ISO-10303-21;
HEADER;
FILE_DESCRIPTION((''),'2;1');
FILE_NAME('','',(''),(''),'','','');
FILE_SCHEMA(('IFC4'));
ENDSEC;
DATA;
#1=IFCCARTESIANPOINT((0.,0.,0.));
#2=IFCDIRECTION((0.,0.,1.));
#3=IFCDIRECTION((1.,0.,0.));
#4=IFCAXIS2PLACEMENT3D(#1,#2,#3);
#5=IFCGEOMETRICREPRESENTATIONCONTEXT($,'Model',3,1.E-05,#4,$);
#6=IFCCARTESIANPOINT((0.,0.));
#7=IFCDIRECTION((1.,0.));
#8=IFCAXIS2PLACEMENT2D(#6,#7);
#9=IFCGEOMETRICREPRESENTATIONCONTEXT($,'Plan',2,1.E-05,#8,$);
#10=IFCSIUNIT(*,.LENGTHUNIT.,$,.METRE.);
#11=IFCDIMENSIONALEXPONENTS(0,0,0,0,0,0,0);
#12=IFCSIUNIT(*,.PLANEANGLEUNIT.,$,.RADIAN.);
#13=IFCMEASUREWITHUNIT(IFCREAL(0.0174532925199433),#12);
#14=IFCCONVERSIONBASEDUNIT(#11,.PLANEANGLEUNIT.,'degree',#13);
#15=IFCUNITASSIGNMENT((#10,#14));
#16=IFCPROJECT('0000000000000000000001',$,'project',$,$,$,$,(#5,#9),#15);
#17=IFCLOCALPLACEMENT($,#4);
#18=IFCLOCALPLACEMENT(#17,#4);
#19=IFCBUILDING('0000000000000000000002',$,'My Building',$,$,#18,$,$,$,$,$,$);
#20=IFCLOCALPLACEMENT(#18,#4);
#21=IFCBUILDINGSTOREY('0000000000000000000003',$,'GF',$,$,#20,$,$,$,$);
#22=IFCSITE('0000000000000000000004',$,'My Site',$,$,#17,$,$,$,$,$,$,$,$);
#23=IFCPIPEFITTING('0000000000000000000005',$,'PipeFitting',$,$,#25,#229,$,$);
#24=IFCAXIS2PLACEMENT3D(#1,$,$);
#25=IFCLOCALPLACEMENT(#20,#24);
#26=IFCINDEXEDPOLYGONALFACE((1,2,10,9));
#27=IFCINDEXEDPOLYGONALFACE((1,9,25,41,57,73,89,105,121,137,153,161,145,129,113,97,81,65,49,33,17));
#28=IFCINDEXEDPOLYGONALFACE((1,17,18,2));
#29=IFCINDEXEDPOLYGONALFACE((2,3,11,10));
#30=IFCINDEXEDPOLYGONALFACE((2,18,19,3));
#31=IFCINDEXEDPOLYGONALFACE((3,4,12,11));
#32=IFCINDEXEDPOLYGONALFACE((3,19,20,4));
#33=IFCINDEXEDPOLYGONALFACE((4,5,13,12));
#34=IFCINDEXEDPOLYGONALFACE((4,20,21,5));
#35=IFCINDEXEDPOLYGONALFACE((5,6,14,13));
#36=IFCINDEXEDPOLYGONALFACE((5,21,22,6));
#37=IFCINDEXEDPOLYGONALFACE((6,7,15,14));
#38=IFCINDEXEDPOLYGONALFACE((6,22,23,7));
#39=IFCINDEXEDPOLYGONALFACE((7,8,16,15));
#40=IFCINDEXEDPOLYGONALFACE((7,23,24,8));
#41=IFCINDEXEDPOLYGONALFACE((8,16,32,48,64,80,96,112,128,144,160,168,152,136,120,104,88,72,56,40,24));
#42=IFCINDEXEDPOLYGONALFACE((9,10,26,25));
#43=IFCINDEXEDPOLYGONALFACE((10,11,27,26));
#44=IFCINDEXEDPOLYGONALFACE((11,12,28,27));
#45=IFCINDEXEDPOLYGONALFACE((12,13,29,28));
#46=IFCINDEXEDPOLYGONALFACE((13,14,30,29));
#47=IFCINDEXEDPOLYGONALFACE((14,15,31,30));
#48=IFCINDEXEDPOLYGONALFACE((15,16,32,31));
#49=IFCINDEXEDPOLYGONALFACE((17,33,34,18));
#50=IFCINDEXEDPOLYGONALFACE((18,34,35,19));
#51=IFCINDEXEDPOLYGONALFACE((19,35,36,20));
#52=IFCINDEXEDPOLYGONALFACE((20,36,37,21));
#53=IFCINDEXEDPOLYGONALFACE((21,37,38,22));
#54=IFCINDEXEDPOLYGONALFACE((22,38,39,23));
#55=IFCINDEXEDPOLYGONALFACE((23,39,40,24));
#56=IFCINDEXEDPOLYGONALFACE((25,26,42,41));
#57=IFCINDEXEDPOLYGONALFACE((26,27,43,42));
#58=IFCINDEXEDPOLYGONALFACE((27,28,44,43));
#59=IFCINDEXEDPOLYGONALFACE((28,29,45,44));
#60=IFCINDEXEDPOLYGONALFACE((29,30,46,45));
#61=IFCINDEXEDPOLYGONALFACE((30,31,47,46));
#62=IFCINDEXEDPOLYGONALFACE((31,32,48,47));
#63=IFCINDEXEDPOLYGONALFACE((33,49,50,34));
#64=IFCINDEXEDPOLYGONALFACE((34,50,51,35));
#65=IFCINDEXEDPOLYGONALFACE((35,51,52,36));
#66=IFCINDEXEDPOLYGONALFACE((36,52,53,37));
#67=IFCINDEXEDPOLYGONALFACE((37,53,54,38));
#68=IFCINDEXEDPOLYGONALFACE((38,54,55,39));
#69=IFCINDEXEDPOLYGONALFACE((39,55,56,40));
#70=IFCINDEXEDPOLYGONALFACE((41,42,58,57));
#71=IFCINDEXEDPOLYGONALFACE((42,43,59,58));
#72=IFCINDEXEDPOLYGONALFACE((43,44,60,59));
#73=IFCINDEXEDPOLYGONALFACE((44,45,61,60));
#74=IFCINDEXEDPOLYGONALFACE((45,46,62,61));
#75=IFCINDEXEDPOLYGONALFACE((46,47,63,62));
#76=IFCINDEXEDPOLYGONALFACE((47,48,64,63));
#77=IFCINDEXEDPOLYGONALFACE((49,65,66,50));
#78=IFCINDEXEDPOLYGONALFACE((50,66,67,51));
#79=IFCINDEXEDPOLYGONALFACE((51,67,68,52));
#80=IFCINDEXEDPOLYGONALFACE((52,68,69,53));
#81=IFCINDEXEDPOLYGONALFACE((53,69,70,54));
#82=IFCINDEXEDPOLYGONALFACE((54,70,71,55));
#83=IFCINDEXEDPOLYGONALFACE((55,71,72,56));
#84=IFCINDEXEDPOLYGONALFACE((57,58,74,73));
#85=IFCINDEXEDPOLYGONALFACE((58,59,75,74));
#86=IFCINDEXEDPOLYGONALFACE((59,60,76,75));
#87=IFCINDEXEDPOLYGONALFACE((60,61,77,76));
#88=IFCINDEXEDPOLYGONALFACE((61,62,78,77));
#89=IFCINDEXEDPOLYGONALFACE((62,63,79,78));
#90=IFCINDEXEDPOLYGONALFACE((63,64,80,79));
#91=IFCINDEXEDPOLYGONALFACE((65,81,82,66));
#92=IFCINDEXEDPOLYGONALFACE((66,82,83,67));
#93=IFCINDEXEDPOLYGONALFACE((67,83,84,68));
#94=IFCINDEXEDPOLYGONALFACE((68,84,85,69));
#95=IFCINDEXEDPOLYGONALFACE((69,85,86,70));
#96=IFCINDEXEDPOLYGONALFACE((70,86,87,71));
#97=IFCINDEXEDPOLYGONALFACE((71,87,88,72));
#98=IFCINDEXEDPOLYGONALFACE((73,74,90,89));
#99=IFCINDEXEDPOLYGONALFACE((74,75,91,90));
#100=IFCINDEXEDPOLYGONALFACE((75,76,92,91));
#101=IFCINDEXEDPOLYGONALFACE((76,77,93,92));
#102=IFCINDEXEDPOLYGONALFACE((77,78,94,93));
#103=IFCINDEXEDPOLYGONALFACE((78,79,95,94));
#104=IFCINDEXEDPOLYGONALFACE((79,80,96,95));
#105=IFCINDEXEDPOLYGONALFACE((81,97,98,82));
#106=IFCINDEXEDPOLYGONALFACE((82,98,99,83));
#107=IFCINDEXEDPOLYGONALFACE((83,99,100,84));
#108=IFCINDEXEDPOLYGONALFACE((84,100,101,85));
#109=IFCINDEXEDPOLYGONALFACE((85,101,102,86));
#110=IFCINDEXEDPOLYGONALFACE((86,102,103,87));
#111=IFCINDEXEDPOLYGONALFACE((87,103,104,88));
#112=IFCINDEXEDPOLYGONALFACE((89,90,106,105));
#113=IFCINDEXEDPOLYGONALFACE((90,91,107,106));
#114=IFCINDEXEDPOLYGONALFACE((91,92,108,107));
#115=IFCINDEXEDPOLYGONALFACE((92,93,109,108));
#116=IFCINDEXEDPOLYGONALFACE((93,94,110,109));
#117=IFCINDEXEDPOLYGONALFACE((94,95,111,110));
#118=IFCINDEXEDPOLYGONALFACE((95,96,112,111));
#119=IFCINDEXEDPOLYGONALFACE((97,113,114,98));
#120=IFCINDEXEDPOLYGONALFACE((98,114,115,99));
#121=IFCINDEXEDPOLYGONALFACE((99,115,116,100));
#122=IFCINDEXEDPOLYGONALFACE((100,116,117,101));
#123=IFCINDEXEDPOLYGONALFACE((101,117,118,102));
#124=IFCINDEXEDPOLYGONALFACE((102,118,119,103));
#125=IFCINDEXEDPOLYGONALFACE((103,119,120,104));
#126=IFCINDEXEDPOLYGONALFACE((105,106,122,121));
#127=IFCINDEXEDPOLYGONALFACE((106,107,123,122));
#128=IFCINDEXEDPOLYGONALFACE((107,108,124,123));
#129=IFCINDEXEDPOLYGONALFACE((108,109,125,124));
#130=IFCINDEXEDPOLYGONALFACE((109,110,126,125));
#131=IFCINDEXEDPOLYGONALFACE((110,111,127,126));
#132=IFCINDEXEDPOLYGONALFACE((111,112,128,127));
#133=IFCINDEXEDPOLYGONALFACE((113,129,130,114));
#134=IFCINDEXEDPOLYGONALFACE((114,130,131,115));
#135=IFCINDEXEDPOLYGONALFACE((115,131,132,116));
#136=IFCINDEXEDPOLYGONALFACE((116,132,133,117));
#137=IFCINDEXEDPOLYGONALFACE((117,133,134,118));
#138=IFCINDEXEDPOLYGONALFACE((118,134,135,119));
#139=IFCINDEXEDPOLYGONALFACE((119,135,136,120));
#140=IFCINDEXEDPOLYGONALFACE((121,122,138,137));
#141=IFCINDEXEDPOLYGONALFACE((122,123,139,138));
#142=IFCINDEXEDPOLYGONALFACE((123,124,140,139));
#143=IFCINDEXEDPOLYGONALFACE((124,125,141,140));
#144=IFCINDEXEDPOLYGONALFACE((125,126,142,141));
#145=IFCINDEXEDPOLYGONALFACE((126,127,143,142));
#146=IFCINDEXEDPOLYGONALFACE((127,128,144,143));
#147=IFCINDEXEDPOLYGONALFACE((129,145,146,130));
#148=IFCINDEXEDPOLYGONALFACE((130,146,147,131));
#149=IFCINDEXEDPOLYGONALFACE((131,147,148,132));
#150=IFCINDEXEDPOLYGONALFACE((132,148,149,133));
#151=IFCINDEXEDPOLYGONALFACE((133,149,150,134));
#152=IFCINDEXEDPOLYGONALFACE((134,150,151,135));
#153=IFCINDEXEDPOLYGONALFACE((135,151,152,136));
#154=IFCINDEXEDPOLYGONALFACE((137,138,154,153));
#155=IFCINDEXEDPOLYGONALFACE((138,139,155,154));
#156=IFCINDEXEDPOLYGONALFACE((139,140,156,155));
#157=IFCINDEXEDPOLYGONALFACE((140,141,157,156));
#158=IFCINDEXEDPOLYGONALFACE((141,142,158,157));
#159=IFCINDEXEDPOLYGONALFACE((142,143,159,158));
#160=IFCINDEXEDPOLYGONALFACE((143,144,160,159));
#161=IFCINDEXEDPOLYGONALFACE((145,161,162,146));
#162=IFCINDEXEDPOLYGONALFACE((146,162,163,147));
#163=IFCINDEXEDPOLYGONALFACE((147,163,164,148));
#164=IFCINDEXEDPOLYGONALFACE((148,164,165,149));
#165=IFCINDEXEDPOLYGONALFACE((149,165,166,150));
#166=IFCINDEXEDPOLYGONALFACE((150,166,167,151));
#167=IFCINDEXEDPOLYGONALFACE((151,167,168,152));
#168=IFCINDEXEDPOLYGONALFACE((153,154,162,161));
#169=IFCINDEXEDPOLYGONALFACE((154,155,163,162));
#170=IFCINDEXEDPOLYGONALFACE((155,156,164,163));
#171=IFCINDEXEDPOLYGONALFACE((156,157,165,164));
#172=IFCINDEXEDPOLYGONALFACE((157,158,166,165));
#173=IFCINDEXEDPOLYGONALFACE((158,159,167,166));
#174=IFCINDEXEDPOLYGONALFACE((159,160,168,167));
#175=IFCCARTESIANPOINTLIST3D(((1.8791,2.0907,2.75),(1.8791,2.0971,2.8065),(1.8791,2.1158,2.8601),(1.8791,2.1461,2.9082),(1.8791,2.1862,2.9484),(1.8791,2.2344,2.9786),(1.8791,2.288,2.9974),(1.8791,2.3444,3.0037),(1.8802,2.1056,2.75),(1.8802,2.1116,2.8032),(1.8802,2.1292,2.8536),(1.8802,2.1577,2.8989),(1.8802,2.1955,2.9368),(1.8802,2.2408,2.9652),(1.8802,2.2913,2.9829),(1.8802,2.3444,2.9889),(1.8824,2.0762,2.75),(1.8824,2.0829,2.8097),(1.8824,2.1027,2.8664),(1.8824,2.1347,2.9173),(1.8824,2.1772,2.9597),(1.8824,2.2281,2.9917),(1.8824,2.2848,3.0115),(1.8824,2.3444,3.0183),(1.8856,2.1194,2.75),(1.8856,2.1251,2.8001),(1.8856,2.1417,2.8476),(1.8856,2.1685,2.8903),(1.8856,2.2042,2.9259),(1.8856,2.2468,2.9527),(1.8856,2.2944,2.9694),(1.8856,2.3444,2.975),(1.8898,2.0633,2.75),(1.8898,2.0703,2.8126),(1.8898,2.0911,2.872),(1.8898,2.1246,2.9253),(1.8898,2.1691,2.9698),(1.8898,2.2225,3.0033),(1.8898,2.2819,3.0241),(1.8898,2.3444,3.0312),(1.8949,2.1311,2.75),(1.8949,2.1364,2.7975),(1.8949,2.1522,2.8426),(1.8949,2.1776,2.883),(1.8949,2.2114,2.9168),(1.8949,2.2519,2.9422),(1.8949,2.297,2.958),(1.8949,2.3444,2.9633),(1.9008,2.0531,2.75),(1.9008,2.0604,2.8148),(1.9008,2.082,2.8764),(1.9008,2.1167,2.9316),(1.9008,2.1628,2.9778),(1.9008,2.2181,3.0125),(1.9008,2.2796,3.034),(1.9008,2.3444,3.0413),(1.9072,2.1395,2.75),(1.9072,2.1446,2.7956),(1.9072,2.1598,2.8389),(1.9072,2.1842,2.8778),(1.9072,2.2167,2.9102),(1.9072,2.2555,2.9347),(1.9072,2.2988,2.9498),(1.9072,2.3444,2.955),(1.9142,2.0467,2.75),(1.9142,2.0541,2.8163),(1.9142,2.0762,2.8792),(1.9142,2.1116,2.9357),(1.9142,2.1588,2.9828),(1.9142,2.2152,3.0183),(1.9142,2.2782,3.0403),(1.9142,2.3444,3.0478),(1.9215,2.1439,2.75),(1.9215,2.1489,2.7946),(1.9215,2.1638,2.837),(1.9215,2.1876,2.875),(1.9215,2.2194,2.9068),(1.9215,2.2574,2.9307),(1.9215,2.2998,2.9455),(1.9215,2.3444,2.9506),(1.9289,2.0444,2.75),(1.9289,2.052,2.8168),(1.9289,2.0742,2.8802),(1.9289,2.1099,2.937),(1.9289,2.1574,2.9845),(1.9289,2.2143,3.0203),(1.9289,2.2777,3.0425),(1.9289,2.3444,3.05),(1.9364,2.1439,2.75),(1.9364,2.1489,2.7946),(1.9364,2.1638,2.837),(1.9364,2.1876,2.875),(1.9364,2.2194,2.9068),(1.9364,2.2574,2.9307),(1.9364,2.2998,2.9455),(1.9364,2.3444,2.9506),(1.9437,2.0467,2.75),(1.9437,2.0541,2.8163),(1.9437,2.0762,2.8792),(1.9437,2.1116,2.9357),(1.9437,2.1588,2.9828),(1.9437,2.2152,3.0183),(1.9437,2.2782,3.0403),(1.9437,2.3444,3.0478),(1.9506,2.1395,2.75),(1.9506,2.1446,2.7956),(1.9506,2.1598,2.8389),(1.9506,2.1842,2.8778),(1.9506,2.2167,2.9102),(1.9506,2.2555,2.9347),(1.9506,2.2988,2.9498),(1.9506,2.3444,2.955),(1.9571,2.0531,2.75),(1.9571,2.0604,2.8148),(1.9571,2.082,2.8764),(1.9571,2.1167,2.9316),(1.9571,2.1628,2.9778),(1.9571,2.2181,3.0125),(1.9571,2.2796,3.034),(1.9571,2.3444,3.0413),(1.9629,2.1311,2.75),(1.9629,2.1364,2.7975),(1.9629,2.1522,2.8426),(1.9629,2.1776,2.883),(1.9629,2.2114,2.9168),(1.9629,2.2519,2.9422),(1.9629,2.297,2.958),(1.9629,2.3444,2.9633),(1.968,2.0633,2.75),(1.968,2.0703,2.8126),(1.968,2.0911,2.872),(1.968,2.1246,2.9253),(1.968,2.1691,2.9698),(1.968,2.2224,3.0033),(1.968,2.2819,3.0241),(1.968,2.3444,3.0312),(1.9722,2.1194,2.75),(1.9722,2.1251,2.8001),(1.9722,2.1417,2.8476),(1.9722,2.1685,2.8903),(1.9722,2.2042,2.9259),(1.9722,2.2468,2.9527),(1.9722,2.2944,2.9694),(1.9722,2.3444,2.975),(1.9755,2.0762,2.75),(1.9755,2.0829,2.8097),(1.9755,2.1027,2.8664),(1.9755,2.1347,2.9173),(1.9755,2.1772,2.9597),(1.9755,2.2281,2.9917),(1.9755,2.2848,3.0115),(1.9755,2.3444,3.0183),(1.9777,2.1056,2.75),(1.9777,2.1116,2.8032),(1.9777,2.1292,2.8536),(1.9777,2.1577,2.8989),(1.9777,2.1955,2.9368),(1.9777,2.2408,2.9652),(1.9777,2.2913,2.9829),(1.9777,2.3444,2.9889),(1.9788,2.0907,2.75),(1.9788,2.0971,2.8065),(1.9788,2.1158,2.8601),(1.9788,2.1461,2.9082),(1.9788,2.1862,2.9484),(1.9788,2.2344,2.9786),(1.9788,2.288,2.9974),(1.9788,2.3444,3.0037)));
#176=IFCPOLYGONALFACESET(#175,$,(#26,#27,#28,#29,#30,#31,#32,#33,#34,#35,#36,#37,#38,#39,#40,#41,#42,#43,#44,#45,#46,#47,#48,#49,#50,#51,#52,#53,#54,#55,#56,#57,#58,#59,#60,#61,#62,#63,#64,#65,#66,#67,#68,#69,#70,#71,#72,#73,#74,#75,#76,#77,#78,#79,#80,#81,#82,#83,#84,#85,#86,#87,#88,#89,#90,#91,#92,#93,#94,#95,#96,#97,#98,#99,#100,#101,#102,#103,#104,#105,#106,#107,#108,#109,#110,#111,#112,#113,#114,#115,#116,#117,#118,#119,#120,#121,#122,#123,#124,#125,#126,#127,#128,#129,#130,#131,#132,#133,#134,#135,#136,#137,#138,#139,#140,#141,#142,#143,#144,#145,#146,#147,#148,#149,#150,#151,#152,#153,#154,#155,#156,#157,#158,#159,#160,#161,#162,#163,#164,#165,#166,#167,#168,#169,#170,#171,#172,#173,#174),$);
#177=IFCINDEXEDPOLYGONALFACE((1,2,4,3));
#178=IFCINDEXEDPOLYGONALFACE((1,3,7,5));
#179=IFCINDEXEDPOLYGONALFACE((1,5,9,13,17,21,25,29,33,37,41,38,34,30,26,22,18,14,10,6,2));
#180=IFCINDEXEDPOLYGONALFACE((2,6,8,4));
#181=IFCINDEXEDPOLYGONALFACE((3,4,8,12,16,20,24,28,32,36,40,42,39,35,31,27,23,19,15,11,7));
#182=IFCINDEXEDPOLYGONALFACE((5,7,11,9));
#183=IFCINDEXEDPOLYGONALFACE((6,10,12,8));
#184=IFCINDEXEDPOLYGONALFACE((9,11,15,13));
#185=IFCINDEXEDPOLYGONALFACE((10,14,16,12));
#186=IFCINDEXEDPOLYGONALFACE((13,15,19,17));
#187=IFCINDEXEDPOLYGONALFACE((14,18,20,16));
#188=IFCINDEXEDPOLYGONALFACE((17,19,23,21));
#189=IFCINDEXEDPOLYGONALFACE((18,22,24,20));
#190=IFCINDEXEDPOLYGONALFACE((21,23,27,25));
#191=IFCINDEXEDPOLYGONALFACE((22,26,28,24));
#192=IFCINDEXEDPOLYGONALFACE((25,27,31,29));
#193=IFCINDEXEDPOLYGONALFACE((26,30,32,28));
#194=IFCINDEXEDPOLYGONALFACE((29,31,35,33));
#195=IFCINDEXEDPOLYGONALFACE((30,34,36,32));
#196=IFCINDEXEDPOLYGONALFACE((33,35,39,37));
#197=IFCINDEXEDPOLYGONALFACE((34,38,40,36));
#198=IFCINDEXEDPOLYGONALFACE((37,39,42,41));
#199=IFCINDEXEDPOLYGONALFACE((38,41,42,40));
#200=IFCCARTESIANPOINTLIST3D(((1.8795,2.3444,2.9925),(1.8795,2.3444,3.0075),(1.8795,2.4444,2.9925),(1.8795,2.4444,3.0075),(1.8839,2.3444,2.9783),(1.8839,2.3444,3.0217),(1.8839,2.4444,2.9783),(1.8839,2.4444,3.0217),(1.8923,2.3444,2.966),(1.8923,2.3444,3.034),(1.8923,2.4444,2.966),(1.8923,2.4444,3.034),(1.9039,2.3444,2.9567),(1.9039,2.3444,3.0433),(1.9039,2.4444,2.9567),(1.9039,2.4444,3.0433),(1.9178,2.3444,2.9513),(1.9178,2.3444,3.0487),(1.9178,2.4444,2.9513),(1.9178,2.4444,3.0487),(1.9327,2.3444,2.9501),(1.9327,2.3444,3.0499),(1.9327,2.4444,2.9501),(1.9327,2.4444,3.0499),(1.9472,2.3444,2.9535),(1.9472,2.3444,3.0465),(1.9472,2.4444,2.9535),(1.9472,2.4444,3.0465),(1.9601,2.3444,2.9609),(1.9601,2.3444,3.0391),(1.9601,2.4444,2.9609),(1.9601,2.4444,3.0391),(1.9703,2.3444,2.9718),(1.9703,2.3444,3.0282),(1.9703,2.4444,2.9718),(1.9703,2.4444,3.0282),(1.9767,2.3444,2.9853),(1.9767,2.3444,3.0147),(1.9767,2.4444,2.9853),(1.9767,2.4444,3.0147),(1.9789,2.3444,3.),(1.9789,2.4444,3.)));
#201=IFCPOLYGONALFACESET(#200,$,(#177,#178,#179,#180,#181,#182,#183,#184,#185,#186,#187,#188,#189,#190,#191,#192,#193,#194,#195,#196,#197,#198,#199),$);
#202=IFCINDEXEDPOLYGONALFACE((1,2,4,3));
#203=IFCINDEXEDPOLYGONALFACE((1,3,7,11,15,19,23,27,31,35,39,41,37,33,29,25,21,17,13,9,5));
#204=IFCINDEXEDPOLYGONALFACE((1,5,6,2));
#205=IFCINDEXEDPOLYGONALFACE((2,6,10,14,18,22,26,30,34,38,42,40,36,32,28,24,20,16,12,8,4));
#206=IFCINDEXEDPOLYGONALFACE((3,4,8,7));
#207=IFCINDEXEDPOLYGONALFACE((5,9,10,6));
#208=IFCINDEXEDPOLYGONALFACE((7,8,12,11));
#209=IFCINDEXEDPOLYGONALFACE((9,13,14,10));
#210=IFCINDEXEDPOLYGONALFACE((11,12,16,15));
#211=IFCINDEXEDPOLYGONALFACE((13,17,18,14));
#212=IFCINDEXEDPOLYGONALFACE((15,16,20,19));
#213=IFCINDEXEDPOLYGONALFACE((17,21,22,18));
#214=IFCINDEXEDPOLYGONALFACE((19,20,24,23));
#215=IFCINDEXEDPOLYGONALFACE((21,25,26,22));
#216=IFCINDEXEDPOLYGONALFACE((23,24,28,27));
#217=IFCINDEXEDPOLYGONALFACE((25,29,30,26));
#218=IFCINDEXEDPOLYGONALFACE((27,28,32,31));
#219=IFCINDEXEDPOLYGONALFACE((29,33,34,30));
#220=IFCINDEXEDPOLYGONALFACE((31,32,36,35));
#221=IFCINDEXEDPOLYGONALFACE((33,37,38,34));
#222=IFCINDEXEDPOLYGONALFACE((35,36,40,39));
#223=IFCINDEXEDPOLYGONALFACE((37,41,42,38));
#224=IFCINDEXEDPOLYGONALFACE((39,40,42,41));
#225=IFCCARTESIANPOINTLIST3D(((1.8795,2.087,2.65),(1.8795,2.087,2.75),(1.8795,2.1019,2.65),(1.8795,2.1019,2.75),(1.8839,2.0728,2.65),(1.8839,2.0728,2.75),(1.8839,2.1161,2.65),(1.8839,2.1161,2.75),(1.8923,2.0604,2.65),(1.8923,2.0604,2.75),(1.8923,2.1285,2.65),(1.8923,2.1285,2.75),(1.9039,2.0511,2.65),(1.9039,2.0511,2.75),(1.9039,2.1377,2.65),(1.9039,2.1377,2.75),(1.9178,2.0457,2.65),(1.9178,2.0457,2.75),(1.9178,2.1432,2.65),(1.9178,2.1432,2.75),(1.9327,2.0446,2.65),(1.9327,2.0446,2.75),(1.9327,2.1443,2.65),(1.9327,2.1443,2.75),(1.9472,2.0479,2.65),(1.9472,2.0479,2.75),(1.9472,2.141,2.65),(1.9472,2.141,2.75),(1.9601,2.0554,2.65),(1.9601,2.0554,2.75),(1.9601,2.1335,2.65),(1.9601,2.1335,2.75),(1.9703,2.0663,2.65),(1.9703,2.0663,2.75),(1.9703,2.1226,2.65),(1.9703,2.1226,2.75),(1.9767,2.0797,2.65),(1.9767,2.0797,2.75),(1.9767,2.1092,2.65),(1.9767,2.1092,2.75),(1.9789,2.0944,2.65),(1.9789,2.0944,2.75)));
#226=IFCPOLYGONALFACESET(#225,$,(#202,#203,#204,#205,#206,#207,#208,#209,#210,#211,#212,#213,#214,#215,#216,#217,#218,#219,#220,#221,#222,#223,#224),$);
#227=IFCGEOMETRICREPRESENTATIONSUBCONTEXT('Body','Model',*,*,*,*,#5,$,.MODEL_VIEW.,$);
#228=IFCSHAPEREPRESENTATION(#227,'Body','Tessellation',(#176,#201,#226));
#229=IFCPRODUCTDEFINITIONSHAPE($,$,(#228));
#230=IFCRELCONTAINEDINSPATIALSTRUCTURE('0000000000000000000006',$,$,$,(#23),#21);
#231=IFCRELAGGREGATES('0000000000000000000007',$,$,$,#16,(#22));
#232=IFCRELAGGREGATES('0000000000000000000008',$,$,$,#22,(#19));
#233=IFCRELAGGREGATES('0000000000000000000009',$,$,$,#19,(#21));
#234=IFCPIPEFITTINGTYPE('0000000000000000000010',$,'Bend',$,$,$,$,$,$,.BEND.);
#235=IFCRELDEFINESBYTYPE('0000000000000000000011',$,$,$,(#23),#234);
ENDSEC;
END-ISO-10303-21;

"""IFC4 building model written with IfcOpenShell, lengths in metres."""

from ifc_helpers import new_model, entity, si_unit, converted_unit, frame, origin_with_axes, origin_2d_with_axis, place, context, subcontext, project, spatial, circle, extrude, source, transform, mapped, type_object, type_shapes, element, save


model = new_model("IFC4")

# Units and contexts
model_context = context("Model", 3, precision=1e-05, world=origin_with_axes())
plan_context = context("Plan", 2, precision=1e-05, world=origin_2d_with_axis())
body_context_1 = subcontext(model_context, "Body", "Model", "MODEL_VIEW")
ifc_project = project(units=[si_unit("LENGTHUNIT", "METRE"), converted_unit("PLANEANGLEUNIT", "degree", entity("IfcReal", 0.0174532925199433), si_unit("PLANEANGLEUNIT", "RADIAN"), dimensions=[0, 0, 0, 0, 0, 0, 0])], contexts=[model_context, plan_context])

# Site, building, storey
site_placement = place(None, origin_with_axes())
site = spatial("IfcSite", under=ifc_project, at=site_placement, Name="My Site")
building_placement = place(site_placement, origin_with_axes())
building = spatial("IfcBuilding", under=site, at=building_placement, Name="My Building")
storey_placement = place(building_placement, origin_with_axes())
storey = spatial("IfcBuildingStorey", under=building, at=storey_placement, Name="GF")

# Pipe fitting
pipe_fitting_type = type_object("IfcPipeFittingType", Name="Bend", PredefinedType="BEND")
shared_shape_1 = source(origin_with_axes(), body_context_1, "Body", "SolidModel", [
    entity("IfcSweptDiskSolid", entity("IfcIndexedPolyCurve", entity("IfcCartesianPointList3D", [[0.0, 0.0, 0.1], [0.0, -0.0732, 0.2768], [0.0, -0.25, 0.35]]), [entity("IfcArcIndex", [1, 2, 3])]), 0.05),
    extrude(circle(Radius=0.05), origin_with_axes(), (0.0, 0.0, 1.0), 0.1),
    extrude(circle(Radius=0.05), frame((0.0, -0.25, 0.35), z_axis=(0.0, -1.0, 0.0), x_axis=(1.0, 0.0, 0.0)), (0.0, 0.0, 1.0), 0.1),
])
type_shapes(pipe_fitting_type, [shared_shape_1])
for number, where, z_axis, x_axis, name in (
    (1, (1.9289, 2.4444, 3.0), (0.0, -1.0, 0.0), (1.0, 0.0, 0.0), "PipeFitting"),
):
    element("IfcPipeFitting", number, at=place(storey_placement, frame(where, z_axis=z_axis, x_axis=x_axis)), inside=storey, type_object=pipe_fitting_type, Name=name, context=body_context_1, shape_type="MappedRepresentation", body=[
        mapped(shared_shape_1, transform((0.0, 0.0, 0.0), x_axis=(1.0, 0.0, 0.0), y_axis=(0.0, 1.0, 0.0), z_axis=(0.0, 0.0, 1.0), scale=1.0)),
    ])

save(model, "model.ifc")
